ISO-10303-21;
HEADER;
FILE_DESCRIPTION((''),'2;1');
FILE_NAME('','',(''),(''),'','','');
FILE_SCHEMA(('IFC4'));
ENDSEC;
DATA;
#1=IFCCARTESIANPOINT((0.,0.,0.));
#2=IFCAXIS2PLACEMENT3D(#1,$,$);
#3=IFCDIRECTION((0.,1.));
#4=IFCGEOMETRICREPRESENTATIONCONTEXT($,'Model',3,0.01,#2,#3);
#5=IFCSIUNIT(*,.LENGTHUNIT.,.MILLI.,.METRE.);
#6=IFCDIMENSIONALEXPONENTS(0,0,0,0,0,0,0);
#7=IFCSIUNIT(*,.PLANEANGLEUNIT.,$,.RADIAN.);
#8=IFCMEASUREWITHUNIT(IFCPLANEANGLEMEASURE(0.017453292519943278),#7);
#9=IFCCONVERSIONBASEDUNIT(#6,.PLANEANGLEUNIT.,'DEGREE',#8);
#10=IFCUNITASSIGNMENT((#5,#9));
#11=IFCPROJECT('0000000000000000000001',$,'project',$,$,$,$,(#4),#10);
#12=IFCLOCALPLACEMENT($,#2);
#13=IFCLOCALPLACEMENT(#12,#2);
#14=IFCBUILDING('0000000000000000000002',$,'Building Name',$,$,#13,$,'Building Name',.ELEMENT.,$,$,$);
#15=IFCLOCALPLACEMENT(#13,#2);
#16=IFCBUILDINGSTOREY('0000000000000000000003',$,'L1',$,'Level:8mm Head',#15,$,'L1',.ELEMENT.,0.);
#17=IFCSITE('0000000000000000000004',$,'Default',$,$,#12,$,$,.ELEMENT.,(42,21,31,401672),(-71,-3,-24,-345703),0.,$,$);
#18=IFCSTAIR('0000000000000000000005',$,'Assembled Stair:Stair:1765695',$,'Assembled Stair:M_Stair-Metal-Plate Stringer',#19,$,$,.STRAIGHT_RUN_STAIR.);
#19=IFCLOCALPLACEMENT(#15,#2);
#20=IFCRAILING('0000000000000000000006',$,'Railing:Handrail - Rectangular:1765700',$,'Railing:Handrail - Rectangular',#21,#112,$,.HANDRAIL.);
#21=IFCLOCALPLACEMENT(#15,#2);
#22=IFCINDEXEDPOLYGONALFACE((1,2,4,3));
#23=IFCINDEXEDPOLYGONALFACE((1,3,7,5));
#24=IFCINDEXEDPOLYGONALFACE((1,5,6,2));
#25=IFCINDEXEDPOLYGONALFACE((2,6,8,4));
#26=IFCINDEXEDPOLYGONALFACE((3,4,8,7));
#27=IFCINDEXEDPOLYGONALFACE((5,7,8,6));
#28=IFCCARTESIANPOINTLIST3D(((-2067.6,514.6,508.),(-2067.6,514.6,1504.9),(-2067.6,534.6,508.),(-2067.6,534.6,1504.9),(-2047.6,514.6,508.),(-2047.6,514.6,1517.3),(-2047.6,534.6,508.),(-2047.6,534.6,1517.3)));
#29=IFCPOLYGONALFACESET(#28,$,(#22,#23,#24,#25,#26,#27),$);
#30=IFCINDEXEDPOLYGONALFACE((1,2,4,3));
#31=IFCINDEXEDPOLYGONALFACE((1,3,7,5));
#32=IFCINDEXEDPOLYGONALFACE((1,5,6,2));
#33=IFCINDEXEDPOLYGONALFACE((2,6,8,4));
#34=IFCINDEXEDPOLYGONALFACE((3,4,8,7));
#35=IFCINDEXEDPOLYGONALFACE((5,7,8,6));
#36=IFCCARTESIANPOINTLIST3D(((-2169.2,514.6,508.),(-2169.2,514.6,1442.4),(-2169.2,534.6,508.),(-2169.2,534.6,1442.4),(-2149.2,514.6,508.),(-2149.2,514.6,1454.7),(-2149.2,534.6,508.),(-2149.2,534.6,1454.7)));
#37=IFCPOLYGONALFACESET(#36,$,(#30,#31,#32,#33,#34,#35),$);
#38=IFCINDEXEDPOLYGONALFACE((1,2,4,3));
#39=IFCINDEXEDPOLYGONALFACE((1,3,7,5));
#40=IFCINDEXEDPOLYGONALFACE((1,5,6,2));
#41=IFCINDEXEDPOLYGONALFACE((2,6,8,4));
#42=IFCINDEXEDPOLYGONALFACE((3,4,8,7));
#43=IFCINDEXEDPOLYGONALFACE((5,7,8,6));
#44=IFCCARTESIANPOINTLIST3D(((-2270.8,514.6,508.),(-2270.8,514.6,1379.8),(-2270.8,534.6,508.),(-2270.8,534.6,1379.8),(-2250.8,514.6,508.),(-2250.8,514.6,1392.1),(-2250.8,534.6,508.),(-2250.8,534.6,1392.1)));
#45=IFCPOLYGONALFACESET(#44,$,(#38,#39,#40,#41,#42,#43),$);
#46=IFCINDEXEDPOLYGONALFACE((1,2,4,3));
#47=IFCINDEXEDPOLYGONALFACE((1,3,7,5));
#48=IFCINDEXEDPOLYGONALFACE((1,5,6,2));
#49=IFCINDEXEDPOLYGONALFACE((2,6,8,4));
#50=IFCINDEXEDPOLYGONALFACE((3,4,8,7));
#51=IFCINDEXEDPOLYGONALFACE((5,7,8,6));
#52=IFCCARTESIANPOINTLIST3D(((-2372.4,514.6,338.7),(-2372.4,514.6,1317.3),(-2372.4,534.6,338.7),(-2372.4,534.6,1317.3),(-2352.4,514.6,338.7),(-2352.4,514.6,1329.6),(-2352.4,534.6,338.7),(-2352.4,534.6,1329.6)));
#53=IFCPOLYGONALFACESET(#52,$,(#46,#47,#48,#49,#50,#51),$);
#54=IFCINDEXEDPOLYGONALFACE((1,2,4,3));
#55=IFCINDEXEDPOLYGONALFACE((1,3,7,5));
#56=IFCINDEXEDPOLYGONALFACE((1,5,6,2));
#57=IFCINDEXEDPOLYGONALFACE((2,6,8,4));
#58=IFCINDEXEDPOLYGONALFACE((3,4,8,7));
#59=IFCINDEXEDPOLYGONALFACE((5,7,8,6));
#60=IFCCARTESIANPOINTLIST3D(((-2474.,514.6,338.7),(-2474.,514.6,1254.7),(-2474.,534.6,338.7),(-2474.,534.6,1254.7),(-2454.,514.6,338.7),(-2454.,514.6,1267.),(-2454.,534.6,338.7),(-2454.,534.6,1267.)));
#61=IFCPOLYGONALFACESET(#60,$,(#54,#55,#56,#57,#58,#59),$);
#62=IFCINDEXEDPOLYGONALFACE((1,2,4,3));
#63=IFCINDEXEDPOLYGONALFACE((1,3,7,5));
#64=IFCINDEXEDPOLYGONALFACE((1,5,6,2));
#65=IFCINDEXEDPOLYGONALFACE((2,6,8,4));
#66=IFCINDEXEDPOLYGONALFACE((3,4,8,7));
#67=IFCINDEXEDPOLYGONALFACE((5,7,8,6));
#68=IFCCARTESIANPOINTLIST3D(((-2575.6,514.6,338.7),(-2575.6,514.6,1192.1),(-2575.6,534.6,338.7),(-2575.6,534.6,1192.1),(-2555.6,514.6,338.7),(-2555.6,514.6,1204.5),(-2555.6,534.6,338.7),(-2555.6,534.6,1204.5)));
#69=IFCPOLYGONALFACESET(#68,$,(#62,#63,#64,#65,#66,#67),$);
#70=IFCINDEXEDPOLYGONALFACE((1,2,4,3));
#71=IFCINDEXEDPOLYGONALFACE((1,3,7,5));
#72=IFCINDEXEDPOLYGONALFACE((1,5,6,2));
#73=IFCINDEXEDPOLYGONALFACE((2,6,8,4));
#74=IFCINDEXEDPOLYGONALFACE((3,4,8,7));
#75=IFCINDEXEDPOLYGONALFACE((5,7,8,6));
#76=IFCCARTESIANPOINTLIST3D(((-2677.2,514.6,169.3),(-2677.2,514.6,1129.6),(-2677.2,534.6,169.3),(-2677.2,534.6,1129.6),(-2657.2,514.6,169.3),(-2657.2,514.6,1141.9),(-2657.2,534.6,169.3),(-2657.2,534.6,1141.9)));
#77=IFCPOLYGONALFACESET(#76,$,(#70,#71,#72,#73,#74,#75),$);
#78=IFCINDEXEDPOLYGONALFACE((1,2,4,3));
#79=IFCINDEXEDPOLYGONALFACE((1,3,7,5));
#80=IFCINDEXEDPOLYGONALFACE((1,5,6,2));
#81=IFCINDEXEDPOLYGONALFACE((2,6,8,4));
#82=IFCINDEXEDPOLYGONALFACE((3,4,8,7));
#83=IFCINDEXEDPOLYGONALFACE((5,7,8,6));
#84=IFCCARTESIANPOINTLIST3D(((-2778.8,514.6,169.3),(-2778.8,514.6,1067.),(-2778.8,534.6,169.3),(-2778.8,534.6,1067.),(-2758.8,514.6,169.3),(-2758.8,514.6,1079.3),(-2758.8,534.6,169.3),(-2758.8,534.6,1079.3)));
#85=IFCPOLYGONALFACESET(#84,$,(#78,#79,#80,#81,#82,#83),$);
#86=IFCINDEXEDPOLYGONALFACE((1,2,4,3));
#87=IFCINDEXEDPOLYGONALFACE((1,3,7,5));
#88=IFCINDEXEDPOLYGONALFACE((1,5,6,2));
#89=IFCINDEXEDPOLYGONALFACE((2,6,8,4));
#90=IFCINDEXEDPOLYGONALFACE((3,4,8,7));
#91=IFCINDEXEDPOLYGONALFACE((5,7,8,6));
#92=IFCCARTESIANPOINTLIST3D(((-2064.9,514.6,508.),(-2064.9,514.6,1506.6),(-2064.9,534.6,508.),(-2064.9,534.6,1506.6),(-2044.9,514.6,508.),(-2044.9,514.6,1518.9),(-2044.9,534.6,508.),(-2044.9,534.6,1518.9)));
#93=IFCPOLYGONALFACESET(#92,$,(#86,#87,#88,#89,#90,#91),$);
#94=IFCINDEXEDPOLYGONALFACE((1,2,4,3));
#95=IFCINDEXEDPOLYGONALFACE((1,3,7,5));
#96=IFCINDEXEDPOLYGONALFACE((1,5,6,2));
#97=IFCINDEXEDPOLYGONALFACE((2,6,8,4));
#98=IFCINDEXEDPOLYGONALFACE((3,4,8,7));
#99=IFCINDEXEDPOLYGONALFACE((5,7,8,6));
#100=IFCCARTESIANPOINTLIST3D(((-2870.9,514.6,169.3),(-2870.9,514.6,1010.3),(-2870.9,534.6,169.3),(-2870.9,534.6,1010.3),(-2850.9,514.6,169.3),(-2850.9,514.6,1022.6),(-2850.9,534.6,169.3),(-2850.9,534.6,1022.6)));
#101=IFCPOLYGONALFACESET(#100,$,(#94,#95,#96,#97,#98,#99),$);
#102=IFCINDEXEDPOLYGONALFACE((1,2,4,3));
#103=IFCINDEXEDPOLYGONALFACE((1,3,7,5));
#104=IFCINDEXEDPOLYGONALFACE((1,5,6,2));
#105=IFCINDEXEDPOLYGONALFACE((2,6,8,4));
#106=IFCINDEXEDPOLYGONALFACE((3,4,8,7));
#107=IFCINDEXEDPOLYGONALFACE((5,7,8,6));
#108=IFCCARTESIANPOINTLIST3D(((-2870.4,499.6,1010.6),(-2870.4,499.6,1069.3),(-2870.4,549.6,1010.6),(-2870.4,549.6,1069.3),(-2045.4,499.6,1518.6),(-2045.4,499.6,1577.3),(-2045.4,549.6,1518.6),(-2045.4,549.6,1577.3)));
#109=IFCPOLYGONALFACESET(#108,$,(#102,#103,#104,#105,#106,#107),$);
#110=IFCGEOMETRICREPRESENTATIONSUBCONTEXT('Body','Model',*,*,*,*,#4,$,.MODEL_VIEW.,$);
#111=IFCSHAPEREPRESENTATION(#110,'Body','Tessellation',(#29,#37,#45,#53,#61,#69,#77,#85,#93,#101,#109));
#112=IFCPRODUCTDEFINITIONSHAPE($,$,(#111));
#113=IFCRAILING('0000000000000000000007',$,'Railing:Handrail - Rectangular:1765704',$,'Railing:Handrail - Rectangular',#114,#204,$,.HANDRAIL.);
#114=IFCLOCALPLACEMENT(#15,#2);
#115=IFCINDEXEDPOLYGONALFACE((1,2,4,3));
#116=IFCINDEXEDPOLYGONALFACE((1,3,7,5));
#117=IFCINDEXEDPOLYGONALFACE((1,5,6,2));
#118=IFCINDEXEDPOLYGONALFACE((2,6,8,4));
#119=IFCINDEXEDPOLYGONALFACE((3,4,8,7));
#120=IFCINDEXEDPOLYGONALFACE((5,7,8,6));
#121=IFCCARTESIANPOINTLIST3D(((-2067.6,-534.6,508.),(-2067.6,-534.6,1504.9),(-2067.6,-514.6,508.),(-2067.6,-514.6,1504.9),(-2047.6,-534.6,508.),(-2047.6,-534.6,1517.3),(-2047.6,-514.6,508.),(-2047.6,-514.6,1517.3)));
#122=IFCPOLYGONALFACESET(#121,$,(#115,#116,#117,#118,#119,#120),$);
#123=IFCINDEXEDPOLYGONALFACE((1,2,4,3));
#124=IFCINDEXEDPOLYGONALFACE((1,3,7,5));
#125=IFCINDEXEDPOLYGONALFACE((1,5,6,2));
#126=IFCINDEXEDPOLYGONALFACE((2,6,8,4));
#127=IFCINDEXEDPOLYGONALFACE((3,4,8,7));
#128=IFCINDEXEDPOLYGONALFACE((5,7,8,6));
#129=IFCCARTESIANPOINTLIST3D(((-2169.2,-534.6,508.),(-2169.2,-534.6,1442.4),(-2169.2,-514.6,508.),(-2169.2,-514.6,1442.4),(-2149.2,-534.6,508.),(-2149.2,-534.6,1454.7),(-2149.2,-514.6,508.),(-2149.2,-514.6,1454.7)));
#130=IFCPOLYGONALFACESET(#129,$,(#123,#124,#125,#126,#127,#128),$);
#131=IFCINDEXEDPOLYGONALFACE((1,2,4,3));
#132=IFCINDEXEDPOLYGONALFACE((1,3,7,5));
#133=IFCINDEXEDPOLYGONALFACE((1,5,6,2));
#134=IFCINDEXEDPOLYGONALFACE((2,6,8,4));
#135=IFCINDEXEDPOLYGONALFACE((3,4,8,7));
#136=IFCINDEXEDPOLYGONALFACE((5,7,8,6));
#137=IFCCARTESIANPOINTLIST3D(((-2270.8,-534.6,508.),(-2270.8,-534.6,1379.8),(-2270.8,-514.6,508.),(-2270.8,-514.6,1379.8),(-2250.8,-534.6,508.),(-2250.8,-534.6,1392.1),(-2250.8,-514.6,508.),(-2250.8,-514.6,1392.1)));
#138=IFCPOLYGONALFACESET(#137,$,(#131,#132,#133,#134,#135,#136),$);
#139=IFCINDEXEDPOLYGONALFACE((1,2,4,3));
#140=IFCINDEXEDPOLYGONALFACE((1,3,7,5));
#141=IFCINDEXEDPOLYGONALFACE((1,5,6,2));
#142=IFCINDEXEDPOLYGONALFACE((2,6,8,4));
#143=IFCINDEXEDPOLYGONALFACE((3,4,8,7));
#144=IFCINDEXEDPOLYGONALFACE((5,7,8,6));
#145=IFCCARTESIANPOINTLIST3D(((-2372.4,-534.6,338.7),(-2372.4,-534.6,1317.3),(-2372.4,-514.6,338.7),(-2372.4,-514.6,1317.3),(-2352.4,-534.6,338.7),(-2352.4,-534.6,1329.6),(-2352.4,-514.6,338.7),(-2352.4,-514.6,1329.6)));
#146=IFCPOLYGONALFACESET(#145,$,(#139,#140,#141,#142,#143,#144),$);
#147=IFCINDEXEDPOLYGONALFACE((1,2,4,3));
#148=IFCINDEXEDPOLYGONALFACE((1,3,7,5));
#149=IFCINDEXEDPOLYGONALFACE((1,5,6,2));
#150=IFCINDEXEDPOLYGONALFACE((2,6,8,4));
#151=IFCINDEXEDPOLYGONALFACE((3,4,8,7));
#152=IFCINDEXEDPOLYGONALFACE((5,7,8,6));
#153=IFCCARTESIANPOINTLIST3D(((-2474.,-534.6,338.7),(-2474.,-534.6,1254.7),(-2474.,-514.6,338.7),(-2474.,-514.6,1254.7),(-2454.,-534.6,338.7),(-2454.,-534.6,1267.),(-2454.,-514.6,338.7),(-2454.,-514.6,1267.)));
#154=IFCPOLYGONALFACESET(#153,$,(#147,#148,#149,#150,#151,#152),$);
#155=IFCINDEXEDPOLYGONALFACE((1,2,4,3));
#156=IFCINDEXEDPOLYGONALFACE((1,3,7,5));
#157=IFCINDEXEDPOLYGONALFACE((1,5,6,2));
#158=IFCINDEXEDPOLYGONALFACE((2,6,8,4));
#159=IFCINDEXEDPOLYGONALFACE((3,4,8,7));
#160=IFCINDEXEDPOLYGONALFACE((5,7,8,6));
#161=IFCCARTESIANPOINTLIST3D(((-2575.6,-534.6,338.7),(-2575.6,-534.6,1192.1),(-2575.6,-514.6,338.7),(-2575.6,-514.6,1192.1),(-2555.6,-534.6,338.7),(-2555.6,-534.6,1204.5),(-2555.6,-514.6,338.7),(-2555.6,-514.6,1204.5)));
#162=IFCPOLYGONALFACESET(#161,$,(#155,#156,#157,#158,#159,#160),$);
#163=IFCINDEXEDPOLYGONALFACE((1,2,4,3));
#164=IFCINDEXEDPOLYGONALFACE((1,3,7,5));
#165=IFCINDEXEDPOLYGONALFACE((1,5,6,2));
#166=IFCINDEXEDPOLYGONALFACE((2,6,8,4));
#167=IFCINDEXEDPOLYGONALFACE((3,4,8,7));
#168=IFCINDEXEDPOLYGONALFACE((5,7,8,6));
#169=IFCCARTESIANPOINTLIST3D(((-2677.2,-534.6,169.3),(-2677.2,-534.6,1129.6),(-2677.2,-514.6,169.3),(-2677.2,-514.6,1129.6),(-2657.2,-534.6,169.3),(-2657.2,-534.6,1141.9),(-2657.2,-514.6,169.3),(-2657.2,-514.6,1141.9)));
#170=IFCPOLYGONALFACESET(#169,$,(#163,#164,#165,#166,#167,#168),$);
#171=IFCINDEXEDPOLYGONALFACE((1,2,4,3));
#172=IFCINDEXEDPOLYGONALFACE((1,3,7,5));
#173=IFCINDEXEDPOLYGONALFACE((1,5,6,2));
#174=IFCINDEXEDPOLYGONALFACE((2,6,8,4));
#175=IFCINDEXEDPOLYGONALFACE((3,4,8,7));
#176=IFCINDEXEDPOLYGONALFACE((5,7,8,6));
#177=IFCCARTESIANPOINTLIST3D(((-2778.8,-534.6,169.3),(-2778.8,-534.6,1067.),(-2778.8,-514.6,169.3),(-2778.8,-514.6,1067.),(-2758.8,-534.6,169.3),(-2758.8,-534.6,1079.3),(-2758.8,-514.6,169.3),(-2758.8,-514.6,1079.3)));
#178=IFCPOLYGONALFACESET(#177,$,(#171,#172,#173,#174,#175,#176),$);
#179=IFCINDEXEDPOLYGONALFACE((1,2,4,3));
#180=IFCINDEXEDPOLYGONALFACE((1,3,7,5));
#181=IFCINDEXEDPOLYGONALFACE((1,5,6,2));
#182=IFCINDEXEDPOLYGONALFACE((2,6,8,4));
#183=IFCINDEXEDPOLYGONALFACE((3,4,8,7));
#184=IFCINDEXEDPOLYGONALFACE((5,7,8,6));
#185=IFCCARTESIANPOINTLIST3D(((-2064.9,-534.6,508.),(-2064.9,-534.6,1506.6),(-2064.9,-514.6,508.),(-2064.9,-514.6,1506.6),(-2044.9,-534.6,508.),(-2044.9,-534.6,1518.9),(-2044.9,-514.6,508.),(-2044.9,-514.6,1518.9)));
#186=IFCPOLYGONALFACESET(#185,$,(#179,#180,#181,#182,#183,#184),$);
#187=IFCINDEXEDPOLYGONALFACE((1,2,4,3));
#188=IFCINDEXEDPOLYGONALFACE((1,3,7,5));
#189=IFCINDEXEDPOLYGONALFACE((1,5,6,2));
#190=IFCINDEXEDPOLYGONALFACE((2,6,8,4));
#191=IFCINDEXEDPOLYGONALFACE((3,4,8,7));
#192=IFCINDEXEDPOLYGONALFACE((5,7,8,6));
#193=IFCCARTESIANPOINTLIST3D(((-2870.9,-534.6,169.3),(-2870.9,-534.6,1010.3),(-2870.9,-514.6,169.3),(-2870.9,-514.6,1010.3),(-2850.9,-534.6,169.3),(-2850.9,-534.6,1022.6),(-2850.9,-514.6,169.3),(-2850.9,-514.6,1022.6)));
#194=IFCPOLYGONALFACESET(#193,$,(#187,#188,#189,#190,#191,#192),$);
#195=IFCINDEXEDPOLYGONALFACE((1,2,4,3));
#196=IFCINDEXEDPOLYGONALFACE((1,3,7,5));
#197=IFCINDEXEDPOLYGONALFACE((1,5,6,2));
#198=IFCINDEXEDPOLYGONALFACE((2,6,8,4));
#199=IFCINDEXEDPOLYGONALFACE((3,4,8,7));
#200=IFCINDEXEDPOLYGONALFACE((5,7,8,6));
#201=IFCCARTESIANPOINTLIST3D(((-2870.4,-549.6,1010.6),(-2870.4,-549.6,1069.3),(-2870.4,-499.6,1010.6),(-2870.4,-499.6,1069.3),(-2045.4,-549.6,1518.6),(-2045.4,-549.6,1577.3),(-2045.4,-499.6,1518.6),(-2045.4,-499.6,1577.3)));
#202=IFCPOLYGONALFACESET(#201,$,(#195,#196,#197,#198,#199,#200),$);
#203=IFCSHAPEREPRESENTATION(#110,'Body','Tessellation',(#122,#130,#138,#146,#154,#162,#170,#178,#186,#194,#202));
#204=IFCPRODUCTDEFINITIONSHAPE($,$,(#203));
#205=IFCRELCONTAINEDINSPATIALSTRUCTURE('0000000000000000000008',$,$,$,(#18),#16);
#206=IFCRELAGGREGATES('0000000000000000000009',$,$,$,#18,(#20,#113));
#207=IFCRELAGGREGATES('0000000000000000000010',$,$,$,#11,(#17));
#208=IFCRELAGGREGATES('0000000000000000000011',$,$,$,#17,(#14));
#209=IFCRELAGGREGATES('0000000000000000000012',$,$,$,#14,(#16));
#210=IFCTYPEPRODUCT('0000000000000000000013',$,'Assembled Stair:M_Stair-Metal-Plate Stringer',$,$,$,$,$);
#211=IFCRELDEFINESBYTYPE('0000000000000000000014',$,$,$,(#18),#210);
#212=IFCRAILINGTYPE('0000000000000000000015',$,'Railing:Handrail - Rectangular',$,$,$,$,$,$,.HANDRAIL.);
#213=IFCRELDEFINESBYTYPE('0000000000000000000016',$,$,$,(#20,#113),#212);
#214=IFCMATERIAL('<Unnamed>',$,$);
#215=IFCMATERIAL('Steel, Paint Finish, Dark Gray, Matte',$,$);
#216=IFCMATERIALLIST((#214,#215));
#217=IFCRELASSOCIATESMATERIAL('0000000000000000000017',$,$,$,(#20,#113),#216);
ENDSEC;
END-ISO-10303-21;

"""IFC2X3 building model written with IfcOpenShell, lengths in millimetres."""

from ifc_helpers import new_model, entity, si_unit, converted_unit, direction, frame, origin, place, context, subcontext, project, spatial, polyline, outline, extrude, material, material_list, type_object, element, aggregate, save


model = new_model("IFC2X3")

# Units and contexts
model_context = context("Model", 3, precision=0.01, world=origin(), true_north=direction((0.0, 1.0)))
body_context = subcontext(model_context, "Body", "Model", "MODEL_VIEW")
ifc_project = project(units=[si_unit("LENGTHUNIT", "METRE", prefix="MILLI"), converted_unit("PLANEANGLEUNIT", "DEGREE", entity("IfcPlaneAngleMeasure", 0.017453292519943278), si_unit("PLANEANGLEUNIT", "RADIAN"), dimensions=[0, 0, 0, 0, 0, 0, 0])], contexts=[model_context])

# Site, building, storey
site_placement = place(None, origin())
site = spatial("IfcSite", under=ifc_project, at=site_placement, Name="Default", CompositionType="ELEMENT", RefLatitude=(42, 21, 31, 401672), RefLongitude=(-71, -3, -24, -345703), RefElevation=0.0)
building_placement = place(site_placement, origin())
building = spatial("IfcBuilding", under=site, at=building_placement, Name="Building Name", LongName="Building Name", CompositionType="ELEMENT")
storey_placement = place(building_placement, origin())
storey = spatial("IfcBuildingStorey", under=building, at=storey_placement, Name="L1", ObjectType="Level:8mm Head", LongName="L1", CompositionType="ELEMENT", Elevation=0.0)

# Stair
type_product = type_object("IfcTypeProduct", Name="Assembled Stair:M_Stair-Metal-Plate Stringer")
stair_1_placement = place(storey_placement, origin())
stair_1 = element("IfcStair", 1, at=stair_1_placement, inside=storey, type_object=type_product, Name="Assembled Stair:Stair:1765695", ObjectType="Assembled Stair:M_Stair-Metal-Plate Stringer", ShapeType="STRAIGHT_RUN_STAIR")

# Railings
ifc_material_1 = material(Name="<Unnamed>")
ifc_material_2 = material(Name="Steel, Paint Finish, Dark Gray, Matte")
ifc_material_list = material_list([ifc_material_1, ifc_material_2])
railing_type = type_object("IfcRailingType", Name="Railing:Handrail - Rectangular", PredefinedType="HANDRAIL")
railing_1_placement = place(stair_1_placement, origin())
railing_1 = element("IfcRailing", 2, at=railing_1_placement, type_object=railing_type, material=ifc_material_list, Name="Railing:Handrail - Rectangular:1765700", ObjectType="Railing:Handrail - Rectangular", PredefinedType="HANDRAIL", context=body_context, shape_type="SweptSolid", body=[
    extrude(outline(polyline([(-501.6, -10.0), (495.4, -10.0), (507.7, 10.0), (-501.6, 10.0), (-501.6, -10.0)])), frame((-2057.6, 514.6, 1009.6), z_axis=(0.0, 1.0, 0.0), x_axis=(0.0, 0.0, 1.0)), (0.0, 0.0, 1.0), 20.0),
    extrude(outline(polyline([(-470.3, -10.0), (464.1, -10.0), (476.4, 10.0), (-470.3, 10.0), (-470.3, -10.0)])), frame((-2159.2, 514.6, 978.3), z_axis=(0.0, 1.0, 0.0), x_axis=(0.0, 0.0, 1.0)), (0.0, 0.0, 1.0), 20.0),
    extrude(outline(polyline([(-439.0, -10.0), (432.8, -10.0), (445.1, 10.0), (-439.0, 10.0), (-439.0, -10.0)])), frame((-2260.8, 514.6, 947.0), z_axis=(0.0, 1.0, 0.0), x_axis=(0.0, 0.0, 1.0)), (0.0, 0.0, 1.0), 20.0),
    extrude(outline(polyline([(-492.4, -10.0), (486.2, -10.0), (498.5, 10.0), (-492.4, 10.0), (-492.4, -10.0)])), frame((-2362.4, 514.6, 831.0), z_axis=(0.0, 1.0, 0.0), x_axis=(0.0, 0.0, 1.0)), (0.0, 0.0, 1.0), 20.0),
    extrude(outline(polyline([(-461.1, -10.0), (454.9, -10.0), (467.3, 10.0), (-461.1, 10.0), (-461.1, -10.0)])), frame((-2464.0, 514.6, 799.8), z_axis=(0.0, 1.0, 0.0), x_axis=(0.0, 0.0, 1.0)), (0.0, 0.0, 1.0), 20.0),
    extrude(outline(polyline([(-429.8, -10.0), (423.7, -10.0), (436.0, 10.0), (-429.8, 10.0), (-429.8, -10.0)])), frame((-2565.6, 514.6, 768.5), z_axis=(0.0, 1.0, 0.0), x_axis=(0.0, 0.0, 1.0)), (0.0, 0.0, 1.0), 20.0),
    extrude(outline(polyline([(-483.2, -10.0), (477.0, -10.0), (489.4, 10.0), (-483.2, 10.0), (-483.2, -10.0)])), frame((-2667.2, 514.6, 652.5), z_axis=(0.0, 1.0, 0.0), x_axis=(0.0, 0.0, 1.0)), (0.0, 0.0, 1.0), 20.0),
    extrude(outline(polyline([(-451.9, -10.0), (445.8, -10.0), (458.1, 10.0), (-451.9, 10.0), (-451.9, -10.0)])), frame((-2768.8, 514.6, 621.3), z_axis=(0.0, 1.0, 0.0), x_axis=(0.0, 0.0, 1.0)), (0.0, 0.0, 1.0), 20.0),
    extrude(outline(polyline([(-502.4, -10.0), (496.2, -10.0), (508.5, 10.0), (-502.4, 10.0), (-502.4, -10.0)])), frame((-2054.9, 514.6, 1010.4), z_axis=(0.0, 1.0, 0.0), x_axis=(0.0, 0.0, 1.0)), (0.0, 0.0, 1.0), 20.0),
    extrude(outline(polyline([(-423.6, -10.0), (417.4, -10.0), (429.7, 10.0), (-423.6, 10.0), (-423.6, -10.0)])), frame((-2860.9, 514.6, 592.9), z_axis=(0.0, 1.0, 0.0), x_axis=(0.0, 0.0, 1.0)), (0.0, 0.0, 1.0), 20.0),
    extrude(outline(polyline([(-469.0, -25.0), (499.8, -25.0), (469.0, 25.0), (-499.8, 25.0), (-469.0, -25.0)])), frame((-2457.9, 499.6, 1294.0), z_axis=(0.0, 1.0, 0.0), x_axis=(0.851517, 0.0, 0.524328)), (0.0, 0.0, 1.0), 50.0),
])
railing_2_placement = place(stair_1_placement, origin())
railing_2 = element("IfcRailing", 3, at=railing_2_placement, type_object=railing_type, material=ifc_material_list, Name="Railing:Handrail - Rectangular:1765704", ObjectType="Railing:Handrail - Rectangular", PredefinedType="HANDRAIL", context=body_context, shape_type="SweptSolid", body=[
    extrude(outline(polyline([(251.2, -427.1), (274.7, -427.1), (-254.5, 432.3), (-271.5, 421.8), (251.2, -427.1)])), frame((-2057.6, -534.6, 1009.6), z_axis=(0.0, 1.0, 0.0), x_axis=(0.851517, 0.0, 0.524328)), (0.0, 0.0, 1.0), 20.0),
    extrude(outline(polyline([(234.8, -400.4), (258.3, -400.4), (-238.1, 405.7), (-255.1, 395.2), (234.8, -400.4)])), frame((-2159.2, -534.6, 978.3), z_axis=(0.0, 1.0, 0.0), x_axis=(0.851517, 0.0, 0.524328)), (0.0, 0.0, 1.0), 20.0),
    extrude(outline(polyline([(218.4, -373.8), (241.9, -373.8), (-221.7, 379.1), (-238.7, 368.6), (218.4, -373.8)])), frame((-2260.8, -534.6, 947.0), z_axis=(0.0, 1.0, 0.0), x_axis=(0.851517, 0.0, 0.524328)), (0.0, 0.0, 1.0), 20.0),
    extrude(outline(polyline([(246.4, -419.3), (269.9, -419.3), (-249.7, 424.5), (-266.7, 414.0), (246.4, -419.3)])), frame((-2362.4, -534.6, 831.0), z_axis=(0.0, 1.0, 0.0), x_axis=(0.851517, 0.0, 0.524328)), (0.0, 0.0, 1.0), 20.0),
    extrude(outline(polyline([(230.0, -392.6), (253.5, -392.6), (-233.3, 397.9), (-250.3, 387.4), (230.0, -392.6)])), frame((-2464.0, -534.6, 799.8), z_axis=(0.0, 1.0, 0.0), x_axis=(0.851517, 0.0, 0.524328)), (0.0, 0.0, 1.0), 20.0),
    extrude(outline(polyline([(213.6, -366.0), (237.1, -366.0), (-216.8, 371.2), (-233.9, 360.8), (213.6, -366.0)])), frame((-2565.6, -534.6, 768.5), z_axis=(0.0, 1.0, 0.0), x_axis=(0.851517, 0.0, 0.524328)), (0.0, 0.0, 1.0), 20.0),
    extrude(outline(polyline([(241.6, -411.5), (265.1, -411.5), (-244.8, 416.7), (-261.9, 406.2), (241.6, -411.5)])), frame((-2667.2, -534.6, 652.5), z_axis=(0.0, 1.0, 0.0), x_axis=(0.851517, 0.0, 0.524328)), (0.0, 0.0, 1.0), 20.0),
    extrude(outline(polyline([(225.2, -384.8), (248.7, -384.8), (-228.4, 390.1), (-245.5, 379.6), (225.2, -384.8)])), frame((-2768.8, -534.6, 621.3), z_axis=(0.0, 1.0, 0.0), x_axis=(0.851517, 0.0, 0.524328)), (0.0, 0.0, 1.0), 20.0),
    extrude(outline(polyline([(251.7, -427.8), (275.2, -427.8), (-254.9, 433.0), (-271.9, 422.5), (251.7, -427.8)])), frame((-2054.9, -534.6, 1010.4), z_axis=(0.0, 1.0, 0.0), x_axis=(0.851517, 0.0, 0.524328)), (0.0, 0.0, 1.0), 20.0),
    extrude(outline(polyline([(210.3, -360.7), (233.8, -360.7), (-213.6, 365.9), (-230.6, 355.4), (210.3, -360.7)])), frame((-2860.9, -534.6, 592.9), z_axis=(0.0, 1.0, 0.0), x_axis=(0.851517, 0.0, 0.524328)), (0.0, 0.0, 1.0), 20.0),
    extrude(outline(polyline([(-469.0, -25.0), (499.8, -25.0), (469.0, 25.0), (-499.8, 25.0), (-469.0, -25.0)])), frame((-2457.9, -549.6, 1294.0), z_axis=(0.0, 1.0, 0.0), x_axis=(0.851517, 0.0, 0.524328)), (0.0, 0.0, 1.0), 50.0),
])
aggregate(stair_1, [railing_1, railing_2])

save(model, "model.ifc")
